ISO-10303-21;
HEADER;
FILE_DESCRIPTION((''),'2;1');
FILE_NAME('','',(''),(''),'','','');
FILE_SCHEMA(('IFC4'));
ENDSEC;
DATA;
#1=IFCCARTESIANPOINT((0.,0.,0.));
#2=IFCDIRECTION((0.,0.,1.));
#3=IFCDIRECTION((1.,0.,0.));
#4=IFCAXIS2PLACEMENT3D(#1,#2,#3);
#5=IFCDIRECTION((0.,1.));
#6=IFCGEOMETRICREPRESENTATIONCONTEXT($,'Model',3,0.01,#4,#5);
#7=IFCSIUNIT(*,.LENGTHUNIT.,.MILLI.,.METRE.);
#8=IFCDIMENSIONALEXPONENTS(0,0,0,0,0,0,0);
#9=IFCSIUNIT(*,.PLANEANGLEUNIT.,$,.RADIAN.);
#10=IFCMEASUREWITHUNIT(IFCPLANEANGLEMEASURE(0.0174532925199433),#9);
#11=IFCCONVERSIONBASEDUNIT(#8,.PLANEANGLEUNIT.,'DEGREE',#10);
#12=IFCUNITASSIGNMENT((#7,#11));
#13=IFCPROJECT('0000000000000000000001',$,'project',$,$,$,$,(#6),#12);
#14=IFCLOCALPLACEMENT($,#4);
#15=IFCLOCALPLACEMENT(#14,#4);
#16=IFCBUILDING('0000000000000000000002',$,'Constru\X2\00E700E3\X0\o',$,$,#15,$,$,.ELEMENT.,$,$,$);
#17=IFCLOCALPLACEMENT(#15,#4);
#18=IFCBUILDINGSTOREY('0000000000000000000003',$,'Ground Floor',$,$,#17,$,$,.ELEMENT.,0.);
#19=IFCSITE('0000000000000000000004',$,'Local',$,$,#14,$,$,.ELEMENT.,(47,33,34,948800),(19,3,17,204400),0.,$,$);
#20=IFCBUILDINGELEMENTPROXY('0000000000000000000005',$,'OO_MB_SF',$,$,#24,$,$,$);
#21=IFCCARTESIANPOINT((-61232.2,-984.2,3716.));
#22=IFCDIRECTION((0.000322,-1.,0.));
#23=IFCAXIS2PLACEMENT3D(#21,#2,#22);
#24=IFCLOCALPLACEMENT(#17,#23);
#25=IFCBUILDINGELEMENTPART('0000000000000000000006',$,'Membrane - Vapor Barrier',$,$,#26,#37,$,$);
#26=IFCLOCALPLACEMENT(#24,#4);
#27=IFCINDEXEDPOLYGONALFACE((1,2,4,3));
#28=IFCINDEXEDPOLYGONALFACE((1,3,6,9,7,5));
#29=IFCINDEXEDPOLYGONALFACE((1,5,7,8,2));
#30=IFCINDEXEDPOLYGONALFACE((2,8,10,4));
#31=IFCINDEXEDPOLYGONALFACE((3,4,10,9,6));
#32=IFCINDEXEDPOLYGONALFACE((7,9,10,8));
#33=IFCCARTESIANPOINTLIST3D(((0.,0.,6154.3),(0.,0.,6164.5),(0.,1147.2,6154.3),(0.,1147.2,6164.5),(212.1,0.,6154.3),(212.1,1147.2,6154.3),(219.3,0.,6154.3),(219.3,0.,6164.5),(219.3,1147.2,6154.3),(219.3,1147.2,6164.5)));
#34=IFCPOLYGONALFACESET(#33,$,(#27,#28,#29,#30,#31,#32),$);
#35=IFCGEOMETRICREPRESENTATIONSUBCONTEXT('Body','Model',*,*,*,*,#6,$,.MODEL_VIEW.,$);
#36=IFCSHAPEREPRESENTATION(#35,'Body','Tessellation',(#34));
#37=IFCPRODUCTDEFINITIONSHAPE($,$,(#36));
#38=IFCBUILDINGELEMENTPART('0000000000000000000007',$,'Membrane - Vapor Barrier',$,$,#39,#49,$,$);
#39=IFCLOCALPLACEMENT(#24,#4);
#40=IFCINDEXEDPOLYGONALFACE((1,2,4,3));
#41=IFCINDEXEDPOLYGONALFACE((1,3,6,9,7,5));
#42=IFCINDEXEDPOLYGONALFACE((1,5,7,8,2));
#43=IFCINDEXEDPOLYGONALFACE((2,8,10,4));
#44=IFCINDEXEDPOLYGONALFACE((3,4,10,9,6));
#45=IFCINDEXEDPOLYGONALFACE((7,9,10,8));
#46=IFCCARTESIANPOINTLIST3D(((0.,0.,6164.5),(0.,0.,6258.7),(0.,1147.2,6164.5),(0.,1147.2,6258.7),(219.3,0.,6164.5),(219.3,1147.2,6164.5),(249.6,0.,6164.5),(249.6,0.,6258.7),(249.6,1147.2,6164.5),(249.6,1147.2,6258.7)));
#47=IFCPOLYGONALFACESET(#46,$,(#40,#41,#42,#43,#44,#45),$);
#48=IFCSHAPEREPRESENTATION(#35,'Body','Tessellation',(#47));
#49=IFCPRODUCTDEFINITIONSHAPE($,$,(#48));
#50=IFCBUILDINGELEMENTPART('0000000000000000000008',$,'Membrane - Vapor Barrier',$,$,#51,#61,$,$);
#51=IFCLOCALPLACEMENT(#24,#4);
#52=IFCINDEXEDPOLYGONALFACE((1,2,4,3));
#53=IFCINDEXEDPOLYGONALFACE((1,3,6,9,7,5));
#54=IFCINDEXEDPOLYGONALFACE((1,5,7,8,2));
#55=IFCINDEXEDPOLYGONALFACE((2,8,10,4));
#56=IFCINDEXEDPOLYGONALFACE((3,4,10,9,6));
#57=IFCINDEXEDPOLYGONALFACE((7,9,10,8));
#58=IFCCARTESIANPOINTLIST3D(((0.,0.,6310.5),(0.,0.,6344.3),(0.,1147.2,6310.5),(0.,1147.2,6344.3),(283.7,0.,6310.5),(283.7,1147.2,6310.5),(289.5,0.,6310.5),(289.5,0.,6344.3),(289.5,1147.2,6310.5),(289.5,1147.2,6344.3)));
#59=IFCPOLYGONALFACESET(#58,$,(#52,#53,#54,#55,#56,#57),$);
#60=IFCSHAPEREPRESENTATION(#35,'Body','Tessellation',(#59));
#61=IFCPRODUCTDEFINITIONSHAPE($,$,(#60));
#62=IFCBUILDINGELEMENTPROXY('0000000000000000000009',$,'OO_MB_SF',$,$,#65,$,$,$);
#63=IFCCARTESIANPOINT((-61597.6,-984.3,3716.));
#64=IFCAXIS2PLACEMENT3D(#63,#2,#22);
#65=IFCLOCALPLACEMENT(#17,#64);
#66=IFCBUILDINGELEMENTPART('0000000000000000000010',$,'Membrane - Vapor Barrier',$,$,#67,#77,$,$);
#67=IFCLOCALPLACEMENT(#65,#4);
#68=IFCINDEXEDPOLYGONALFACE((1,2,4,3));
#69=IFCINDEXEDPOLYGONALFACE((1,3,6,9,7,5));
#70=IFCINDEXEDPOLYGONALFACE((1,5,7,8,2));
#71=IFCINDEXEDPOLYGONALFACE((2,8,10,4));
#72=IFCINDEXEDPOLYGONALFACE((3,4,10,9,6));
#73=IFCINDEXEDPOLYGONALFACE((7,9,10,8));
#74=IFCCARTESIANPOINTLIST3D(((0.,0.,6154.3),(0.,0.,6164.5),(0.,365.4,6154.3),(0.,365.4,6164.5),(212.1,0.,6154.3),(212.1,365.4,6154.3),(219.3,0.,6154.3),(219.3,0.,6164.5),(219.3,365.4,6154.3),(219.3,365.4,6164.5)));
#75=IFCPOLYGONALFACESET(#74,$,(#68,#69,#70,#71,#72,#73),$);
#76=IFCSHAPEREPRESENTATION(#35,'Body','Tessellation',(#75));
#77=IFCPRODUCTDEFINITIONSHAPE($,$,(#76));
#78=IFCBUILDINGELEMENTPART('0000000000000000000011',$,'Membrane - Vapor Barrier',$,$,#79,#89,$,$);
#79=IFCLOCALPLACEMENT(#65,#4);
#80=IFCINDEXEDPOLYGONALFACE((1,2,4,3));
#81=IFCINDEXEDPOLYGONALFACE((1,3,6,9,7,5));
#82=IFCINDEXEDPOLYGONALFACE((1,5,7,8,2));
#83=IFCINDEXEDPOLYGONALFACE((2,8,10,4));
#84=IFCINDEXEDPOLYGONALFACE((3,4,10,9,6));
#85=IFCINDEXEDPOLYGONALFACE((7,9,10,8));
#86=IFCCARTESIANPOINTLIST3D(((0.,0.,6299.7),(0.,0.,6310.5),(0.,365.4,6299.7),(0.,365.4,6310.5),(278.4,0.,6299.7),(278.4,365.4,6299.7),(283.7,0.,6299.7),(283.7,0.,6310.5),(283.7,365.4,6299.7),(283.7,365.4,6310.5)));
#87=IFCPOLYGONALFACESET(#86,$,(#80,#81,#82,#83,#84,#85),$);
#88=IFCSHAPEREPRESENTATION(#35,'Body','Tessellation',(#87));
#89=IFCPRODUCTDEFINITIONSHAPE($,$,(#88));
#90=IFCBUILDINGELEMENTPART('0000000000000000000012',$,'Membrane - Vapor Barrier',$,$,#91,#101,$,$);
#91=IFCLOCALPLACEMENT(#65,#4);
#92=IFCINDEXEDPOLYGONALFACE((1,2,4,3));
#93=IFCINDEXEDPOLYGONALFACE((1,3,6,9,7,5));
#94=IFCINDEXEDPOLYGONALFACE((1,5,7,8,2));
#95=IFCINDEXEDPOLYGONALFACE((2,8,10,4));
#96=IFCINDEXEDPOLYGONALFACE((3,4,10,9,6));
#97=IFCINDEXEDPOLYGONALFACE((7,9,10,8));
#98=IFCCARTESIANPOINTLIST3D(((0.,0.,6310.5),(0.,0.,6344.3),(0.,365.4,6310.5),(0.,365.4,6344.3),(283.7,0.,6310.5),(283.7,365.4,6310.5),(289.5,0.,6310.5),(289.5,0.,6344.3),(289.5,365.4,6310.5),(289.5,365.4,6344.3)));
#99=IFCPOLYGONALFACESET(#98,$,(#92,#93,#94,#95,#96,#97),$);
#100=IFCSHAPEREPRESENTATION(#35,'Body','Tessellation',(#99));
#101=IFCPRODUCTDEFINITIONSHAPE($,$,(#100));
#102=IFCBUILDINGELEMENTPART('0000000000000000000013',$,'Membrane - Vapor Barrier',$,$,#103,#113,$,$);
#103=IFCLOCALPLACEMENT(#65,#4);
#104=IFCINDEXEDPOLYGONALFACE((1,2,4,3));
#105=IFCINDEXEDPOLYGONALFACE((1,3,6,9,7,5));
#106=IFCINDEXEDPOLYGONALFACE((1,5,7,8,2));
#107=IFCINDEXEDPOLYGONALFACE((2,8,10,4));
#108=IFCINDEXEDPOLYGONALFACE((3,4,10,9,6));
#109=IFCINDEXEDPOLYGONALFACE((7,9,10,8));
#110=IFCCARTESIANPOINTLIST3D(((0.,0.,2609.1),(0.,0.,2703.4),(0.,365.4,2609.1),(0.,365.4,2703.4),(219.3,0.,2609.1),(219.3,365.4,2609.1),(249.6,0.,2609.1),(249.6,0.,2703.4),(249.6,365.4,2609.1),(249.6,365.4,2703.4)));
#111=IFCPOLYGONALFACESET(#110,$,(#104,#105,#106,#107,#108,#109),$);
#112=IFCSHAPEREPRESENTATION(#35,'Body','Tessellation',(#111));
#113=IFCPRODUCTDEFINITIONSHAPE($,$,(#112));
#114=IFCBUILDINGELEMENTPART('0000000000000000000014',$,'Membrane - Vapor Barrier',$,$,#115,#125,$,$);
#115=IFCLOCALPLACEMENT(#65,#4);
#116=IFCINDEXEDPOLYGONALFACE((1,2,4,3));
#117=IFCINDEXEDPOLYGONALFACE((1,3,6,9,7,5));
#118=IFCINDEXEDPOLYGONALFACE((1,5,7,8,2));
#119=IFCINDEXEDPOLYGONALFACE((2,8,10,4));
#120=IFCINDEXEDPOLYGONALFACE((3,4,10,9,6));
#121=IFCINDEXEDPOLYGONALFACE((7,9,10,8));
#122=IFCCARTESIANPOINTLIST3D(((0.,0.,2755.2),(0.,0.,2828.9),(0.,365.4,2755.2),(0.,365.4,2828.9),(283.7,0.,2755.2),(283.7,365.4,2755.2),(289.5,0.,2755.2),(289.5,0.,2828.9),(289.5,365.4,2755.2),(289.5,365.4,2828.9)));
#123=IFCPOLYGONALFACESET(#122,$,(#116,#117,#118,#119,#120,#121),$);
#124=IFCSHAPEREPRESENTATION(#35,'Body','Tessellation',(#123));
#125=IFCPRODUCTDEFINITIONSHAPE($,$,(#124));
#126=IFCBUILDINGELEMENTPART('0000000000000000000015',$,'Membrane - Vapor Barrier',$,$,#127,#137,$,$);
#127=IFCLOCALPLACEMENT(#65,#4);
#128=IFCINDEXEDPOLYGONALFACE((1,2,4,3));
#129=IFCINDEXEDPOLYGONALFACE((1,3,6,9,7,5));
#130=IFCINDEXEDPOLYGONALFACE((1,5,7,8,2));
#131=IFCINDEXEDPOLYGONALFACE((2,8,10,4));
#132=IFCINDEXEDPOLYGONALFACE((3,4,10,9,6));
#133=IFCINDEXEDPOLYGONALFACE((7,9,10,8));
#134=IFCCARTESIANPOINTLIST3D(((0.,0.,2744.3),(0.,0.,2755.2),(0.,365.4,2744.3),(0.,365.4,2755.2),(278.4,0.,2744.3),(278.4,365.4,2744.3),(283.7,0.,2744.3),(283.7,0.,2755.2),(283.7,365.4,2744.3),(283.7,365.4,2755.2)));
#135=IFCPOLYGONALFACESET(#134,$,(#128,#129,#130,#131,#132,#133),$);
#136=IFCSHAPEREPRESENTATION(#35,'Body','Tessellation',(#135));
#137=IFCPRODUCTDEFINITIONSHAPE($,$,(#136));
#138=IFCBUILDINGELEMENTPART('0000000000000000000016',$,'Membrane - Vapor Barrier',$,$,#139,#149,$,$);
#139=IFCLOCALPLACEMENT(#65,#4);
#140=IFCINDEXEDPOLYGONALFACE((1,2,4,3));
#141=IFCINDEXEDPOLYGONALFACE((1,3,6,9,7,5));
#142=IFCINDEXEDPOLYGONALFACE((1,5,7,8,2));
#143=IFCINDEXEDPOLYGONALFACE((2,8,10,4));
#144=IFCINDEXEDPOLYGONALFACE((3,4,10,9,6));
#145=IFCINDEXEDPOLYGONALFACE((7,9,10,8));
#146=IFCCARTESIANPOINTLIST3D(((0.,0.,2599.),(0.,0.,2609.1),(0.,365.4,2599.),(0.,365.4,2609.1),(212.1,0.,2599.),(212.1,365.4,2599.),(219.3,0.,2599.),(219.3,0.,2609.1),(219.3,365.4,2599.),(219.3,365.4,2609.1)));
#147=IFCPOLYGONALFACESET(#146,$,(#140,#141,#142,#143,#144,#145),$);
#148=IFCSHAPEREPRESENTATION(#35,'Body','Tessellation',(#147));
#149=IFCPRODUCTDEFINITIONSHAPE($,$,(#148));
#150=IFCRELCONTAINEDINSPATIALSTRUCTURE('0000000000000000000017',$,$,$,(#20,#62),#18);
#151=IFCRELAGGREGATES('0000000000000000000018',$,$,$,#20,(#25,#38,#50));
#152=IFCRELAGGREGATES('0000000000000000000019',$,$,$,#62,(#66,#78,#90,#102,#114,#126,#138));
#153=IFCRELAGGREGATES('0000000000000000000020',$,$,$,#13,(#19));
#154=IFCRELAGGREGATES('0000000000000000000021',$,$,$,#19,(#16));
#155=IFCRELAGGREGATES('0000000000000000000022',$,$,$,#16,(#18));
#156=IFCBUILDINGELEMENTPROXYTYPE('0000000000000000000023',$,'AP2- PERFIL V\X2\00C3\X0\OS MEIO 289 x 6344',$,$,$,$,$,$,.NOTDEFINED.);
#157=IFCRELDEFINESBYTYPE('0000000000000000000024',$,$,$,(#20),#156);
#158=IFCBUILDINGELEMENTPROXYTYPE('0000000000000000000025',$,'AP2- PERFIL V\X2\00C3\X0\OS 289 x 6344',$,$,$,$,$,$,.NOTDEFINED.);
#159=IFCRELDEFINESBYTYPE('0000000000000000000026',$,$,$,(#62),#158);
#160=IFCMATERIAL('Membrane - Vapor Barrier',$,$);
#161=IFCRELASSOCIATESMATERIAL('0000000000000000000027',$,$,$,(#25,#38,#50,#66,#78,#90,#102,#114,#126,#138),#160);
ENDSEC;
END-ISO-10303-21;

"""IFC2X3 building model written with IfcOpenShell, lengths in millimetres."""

from ifc_helpers import new_model, entity, si_unit, converted_unit, direction, frame, origin_with_axes, place, context, subcontext, project, spatial, polyline, outline, extrude, material, type_object, element, aggregate, save


model = new_model("IFC2X3")

# Units and contexts
model_context = context("Model", 3, precision=0.01, world=origin_with_axes(), true_north=direction((0.0, 1.0)))
body_context = subcontext(model_context, "Body", "Model", "MODEL_VIEW")
ifc_project = project(units=[si_unit("LENGTHUNIT", "METRE", prefix="MILLI"), converted_unit("PLANEANGLEUNIT", "DEGREE", entity("IfcPlaneAngleMeasure", 0.0174532925199433), si_unit("PLANEANGLEUNIT", "RADIAN"), dimensions=[0, 0, 0, 0, 0, 0, 0])], contexts=[model_context])

# Site, building, storey
site_placement = place(None, origin_with_axes())
site = spatial("IfcSite", under=ifc_project, at=site_placement, Name="Local", CompositionType="ELEMENT", RefLatitude=(47, 33, 34, 948800), RefLongitude=(19, 3, 17, 204400), RefElevation=0.0)
building_placement = place(site_placement, origin_with_axes())
building = spatial("IfcBuilding", under=site, at=building_placement, Name="Construção", CompositionType="ELEMENT")
storey_placement = place(building_placement, origin_with_axes())
storey = spatial("IfcBuildingStorey", under=building, at=storey_placement, Name="Ground Floor", CompositionType="ELEMENT", Elevation=0.0)

# Building element proxies, building element parts
building_element_proxy_type_1 = type_object("IfcBuildingElementProxyType", Name="AP2- PERFIL VÃOS MEIO 289 x 6344", PredefinedType="NOTDEFINED")
proxy_1_placement = place(storey_placement, frame((-61232.2, -984.2, 3716.0), z_axis=(0.0, 0.0, 1.0), x_axis=(0.000322, -1.0, 0.0)))
proxy_1 = element("IfcBuildingElementProxy", 1, at=proxy_1_placement, inside=storey, type_object=building_element_proxy_type_1, Name="OO_MB_SF")
ifc_material_1 = material(Name="Membrane - Vapor Barrier")
building_element_part_1_placement = place(proxy_1_placement, origin_with_axes())
building_element_part_1 = element("IfcBuildingElementPart", 2, at=building_element_part_1_placement, material=ifc_material_1, Name="Membrane - Vapor Barrier", context=body_context, shape_type="SweptSolid", body=[
    extrude(outline(polyline([(0.0, 6154.3), (212.1, 6154.3), (219.3, 6154.3), (219.3, 6164.5), (0.0, 6164.5), (0.0, 6154.3)])), frame((0.0, 1147.2, 0.0), z_axis=(0.0, -1.0, 0.0), x_axis=(1.0, 0.0, 0.0)), (0.0, 0.0, 1.0), 1147.2),
])
building_element_part_2_placement = place(proxy_1_placement, origin_with_axes())
building_element_part_2 = element("IfcBuildingElementPart", 3, at=building_element_part_2_placement, material=ifc_material_1, Name="Membrane - Vapor Barrier", context=body_context, shape_type="SweptSolid", body=[
    extrude(outline(polyline([(249.6, 6258.7), (0.0, 6258.7), (0.0, 6164.5), (219.3, 6164.5), (249.6, 6164.5), (249.6, 6258.7)])), frame((0.0, 1147.2, 0.0), z_axis=(0.0, -1.0, 0.0), x_axis=(1.0, 0.0, 0.0)), (0.0, 0.0, 1.0), 1147.2),
])
building_element_part_3_placement = place(proxy_1_placement, origin_with_axes())
building_element_part_3 = element("IfcBuildingElementPart", 4, at=building_element_part_3_placement, material=ifc_material_1, Name="Membrane - Vapor Barrier", context=body_context, shape_type="SweptSolid", body=[
    extrude(outline(polyline([(0.0, 6310.5), (283.7, 6310.5), (289.5, 6310.5), (289.5, 6344.3), (0.0, 6344.3), (0.0, 6310.5)])), frame((0.0, 1147.2, 0.0), z_axis=(0.0, -1.0, 0.0), x_axis=(1.0, 0.0, 0.0)), (0.0, 0.0, 1.0), 1147.2),
])
aggregate(proxy_1, [building_element_part_1, building_element_part_2, building_element_part_3])
building_element_proxy_type_2 = type_object("IfcBuildingElementProxyType", Name="AP2- PERFIL VÃOS 289 x 6344", PredefinedType="NOTDEFINED")
proxy_2_placement = place(storey_placement, frame((-61597.6, -984.3, 3716.0), z_axis=(0.0, 0.0, 1.0), x_axis=(0.000322, -1.0, 0.0)))
proxy_2 = element("IfcBuildingElementProxy", 5, at=proxy_2_placement, inside=storey, type_object=building_element_proxy_type_2, Name="OO_MB_SF")
building_element_part_4_placement = place(proxy_2_placement, origin_with_axes())
building_element_part_4 = element("IfcBuildingElementPart", 6, at=building_element_part_4_placement, material=ifc_material_1, Name="Membrane - Vapor Barrier", context=body_context, shape_type="SweptSolid", body=[
    extrude(outline(polyline([(0.0, 6154.3), (212.1, 6154.3), (219.3, 6154.3), (219.3, 6164.5), (0.0, 6164.5), (0.0, 6154.3)])), frame((0.0, 365.4, 0.0), z_axis=(0.0, -1.0, 0.0), x_axis=(1.0, 0.0, 0.0)), (0.0, 0.0, 1.0), 365.4),
])
building_element_part_5_placement = place(proxy_2_placement, origin_with_axes())
building_element_part_5 = element("IfcBuildingElementPart", 7, at=building_element_part_5_placement, material=ifc_material_1, Name="Membrane - Vapor Barrier", context=body_context, shape_type="SweptSolid", body=[
    extrude(outline(polyline([(0.0, 6299.7), (278.4, 6299.7), (283.7, 6299.7), (283.7, 6310.5), (0.0, 6310.5), (0.0, 6299.7)])), frame((0.0, 365.4, 0.0), z_axis=(0.0, -1.0, 0.0), x_axis=(1.0, 0.0, 0.0)), (0.0, 0.0, 1.0), 365.4),
])
building_element_part_6_placement = place(proxy_2_placement, origin_with_axes())
building_element_part_6 = element("IfcBuildingElementPart", 8, at=building_element_part_6_placement, material=ifc_material_1, Name="Membrane - Vapor Barrier", context=body_context, shape_type="SweptSolid", body=[
    extrude(outline(polyline([(0.0, 6310.5), (283.7, 6310.5), (289.5, 6310.5), (289.5, 6344.3), (0.0, 6344.3), (0.0, 6310.5)])), frame((0.0, 365.4, 0.0), z_axis=(0.0, -1.0, 0.0), x_axis=(1.0, 0.0, 0.0)), (0.0, 0.0, 1.0), 365.4),
])
building_element_part_7_placement = place(proxy_2_placement, origin_with_axes())
building_element_part_7 = element("IfcBuildingElementPart", 9, at=building_element_part_7_placement, material=ifc_material_1, Name="Membrane - Vapor Barrier", context=body_context, shape_type="SweptSolid", body=[
    extrude(outline(polyline([(249.6, 2703.4), (0.0, 2703.4), (0.0, 2609.1), (219.3, 2609.1), (249.6, 2609.1), (249.6, 2703.4)])), frame((0.0, 365.4, 0.0), z_axis=(0.0, -1.0, 0.0), x_axis=(1.0, 0.0, 0.0)), (0.0, 0.0, 1.0), 365.4),
])
building_element_part_8_placement = place(proxy_2_placement, origin_with_axes())
building_element_part_8 = element("IfcBuildingElementPart", 10, at=building_element_part_8_placement, material=ifc_material_1, Name="Membrane - Vapor Barrier", context=body_context, shape_type="SweptSolid", body=[
    extrude(outline(polyline([(0.0, 2755.2), (283.7, 2755.2), (289.5, 2755.2), (289.5, 2828.9), (0.0, 2828.9), (0.0, 2755.2)])), frame((0.0, 365.4, 0.0), z_axis=(0.0, -1.0, 0.0), x_axis=(1.0, 0.0, 0.0)), (0.0, 0.0, 1.0), 365.4),
])
building_element_part_9_placement = place(proxy_2_placement, origin_with_axes())
building_element_part_9 = element("IfcBuildingElementPart", 11, at=building_element_part_9_placement, material=ifc_material_1, Name="Membrane - Vapor Barrier", context=body_context, shape_type="SweptSolid", body=[
    extrude(outline(polyline([(0.0, 2744.3), (278.4, 2744.3), (283.7, 2744.3), (283.7, 2755.2), (0.0, 2755.2), (0.0, 2744.3)])), frame((0.0, 365.4, 0.0), z_axis=(0.0, -1.0, 0.0), x_axis=(1.0, 0.0, 0.0)), (0.0, 0.0, 1.0), 365.4),
])
building_element_part_10_placement = place(proxy_2_placement, origin_with_axes())
building_element_part_10 = element("IfcBuildingElementPart", 12, at=building_element_part_10_placement, material=ifc_material_1, Name="Membrane - Vapor Barrier", context=body_context, shape_type="SweptSolid", body=[
    extrude(outline(polyline([(0.0, 2599.0), (212.1, 2599.0), (219.3, 2599.0), (219.3, 2609.1), (0.0, 2609.1), (0.0, 2599.0)])), frame((0.0, 365.4, 0.0), z_axis=(0.0, -1.0, 0.0), x_axis=(1.0, 0.0, 0.0)), (0.0, 0.0, 1.0), 365.4),
])
aggregate(proxy_2, [building_element_part_4, building_element_part_5, building_element_part_6, building_element_part_7, building_element_part_8, building_element_part_9, building_element_part_10])

save(model, "model.ifc")
